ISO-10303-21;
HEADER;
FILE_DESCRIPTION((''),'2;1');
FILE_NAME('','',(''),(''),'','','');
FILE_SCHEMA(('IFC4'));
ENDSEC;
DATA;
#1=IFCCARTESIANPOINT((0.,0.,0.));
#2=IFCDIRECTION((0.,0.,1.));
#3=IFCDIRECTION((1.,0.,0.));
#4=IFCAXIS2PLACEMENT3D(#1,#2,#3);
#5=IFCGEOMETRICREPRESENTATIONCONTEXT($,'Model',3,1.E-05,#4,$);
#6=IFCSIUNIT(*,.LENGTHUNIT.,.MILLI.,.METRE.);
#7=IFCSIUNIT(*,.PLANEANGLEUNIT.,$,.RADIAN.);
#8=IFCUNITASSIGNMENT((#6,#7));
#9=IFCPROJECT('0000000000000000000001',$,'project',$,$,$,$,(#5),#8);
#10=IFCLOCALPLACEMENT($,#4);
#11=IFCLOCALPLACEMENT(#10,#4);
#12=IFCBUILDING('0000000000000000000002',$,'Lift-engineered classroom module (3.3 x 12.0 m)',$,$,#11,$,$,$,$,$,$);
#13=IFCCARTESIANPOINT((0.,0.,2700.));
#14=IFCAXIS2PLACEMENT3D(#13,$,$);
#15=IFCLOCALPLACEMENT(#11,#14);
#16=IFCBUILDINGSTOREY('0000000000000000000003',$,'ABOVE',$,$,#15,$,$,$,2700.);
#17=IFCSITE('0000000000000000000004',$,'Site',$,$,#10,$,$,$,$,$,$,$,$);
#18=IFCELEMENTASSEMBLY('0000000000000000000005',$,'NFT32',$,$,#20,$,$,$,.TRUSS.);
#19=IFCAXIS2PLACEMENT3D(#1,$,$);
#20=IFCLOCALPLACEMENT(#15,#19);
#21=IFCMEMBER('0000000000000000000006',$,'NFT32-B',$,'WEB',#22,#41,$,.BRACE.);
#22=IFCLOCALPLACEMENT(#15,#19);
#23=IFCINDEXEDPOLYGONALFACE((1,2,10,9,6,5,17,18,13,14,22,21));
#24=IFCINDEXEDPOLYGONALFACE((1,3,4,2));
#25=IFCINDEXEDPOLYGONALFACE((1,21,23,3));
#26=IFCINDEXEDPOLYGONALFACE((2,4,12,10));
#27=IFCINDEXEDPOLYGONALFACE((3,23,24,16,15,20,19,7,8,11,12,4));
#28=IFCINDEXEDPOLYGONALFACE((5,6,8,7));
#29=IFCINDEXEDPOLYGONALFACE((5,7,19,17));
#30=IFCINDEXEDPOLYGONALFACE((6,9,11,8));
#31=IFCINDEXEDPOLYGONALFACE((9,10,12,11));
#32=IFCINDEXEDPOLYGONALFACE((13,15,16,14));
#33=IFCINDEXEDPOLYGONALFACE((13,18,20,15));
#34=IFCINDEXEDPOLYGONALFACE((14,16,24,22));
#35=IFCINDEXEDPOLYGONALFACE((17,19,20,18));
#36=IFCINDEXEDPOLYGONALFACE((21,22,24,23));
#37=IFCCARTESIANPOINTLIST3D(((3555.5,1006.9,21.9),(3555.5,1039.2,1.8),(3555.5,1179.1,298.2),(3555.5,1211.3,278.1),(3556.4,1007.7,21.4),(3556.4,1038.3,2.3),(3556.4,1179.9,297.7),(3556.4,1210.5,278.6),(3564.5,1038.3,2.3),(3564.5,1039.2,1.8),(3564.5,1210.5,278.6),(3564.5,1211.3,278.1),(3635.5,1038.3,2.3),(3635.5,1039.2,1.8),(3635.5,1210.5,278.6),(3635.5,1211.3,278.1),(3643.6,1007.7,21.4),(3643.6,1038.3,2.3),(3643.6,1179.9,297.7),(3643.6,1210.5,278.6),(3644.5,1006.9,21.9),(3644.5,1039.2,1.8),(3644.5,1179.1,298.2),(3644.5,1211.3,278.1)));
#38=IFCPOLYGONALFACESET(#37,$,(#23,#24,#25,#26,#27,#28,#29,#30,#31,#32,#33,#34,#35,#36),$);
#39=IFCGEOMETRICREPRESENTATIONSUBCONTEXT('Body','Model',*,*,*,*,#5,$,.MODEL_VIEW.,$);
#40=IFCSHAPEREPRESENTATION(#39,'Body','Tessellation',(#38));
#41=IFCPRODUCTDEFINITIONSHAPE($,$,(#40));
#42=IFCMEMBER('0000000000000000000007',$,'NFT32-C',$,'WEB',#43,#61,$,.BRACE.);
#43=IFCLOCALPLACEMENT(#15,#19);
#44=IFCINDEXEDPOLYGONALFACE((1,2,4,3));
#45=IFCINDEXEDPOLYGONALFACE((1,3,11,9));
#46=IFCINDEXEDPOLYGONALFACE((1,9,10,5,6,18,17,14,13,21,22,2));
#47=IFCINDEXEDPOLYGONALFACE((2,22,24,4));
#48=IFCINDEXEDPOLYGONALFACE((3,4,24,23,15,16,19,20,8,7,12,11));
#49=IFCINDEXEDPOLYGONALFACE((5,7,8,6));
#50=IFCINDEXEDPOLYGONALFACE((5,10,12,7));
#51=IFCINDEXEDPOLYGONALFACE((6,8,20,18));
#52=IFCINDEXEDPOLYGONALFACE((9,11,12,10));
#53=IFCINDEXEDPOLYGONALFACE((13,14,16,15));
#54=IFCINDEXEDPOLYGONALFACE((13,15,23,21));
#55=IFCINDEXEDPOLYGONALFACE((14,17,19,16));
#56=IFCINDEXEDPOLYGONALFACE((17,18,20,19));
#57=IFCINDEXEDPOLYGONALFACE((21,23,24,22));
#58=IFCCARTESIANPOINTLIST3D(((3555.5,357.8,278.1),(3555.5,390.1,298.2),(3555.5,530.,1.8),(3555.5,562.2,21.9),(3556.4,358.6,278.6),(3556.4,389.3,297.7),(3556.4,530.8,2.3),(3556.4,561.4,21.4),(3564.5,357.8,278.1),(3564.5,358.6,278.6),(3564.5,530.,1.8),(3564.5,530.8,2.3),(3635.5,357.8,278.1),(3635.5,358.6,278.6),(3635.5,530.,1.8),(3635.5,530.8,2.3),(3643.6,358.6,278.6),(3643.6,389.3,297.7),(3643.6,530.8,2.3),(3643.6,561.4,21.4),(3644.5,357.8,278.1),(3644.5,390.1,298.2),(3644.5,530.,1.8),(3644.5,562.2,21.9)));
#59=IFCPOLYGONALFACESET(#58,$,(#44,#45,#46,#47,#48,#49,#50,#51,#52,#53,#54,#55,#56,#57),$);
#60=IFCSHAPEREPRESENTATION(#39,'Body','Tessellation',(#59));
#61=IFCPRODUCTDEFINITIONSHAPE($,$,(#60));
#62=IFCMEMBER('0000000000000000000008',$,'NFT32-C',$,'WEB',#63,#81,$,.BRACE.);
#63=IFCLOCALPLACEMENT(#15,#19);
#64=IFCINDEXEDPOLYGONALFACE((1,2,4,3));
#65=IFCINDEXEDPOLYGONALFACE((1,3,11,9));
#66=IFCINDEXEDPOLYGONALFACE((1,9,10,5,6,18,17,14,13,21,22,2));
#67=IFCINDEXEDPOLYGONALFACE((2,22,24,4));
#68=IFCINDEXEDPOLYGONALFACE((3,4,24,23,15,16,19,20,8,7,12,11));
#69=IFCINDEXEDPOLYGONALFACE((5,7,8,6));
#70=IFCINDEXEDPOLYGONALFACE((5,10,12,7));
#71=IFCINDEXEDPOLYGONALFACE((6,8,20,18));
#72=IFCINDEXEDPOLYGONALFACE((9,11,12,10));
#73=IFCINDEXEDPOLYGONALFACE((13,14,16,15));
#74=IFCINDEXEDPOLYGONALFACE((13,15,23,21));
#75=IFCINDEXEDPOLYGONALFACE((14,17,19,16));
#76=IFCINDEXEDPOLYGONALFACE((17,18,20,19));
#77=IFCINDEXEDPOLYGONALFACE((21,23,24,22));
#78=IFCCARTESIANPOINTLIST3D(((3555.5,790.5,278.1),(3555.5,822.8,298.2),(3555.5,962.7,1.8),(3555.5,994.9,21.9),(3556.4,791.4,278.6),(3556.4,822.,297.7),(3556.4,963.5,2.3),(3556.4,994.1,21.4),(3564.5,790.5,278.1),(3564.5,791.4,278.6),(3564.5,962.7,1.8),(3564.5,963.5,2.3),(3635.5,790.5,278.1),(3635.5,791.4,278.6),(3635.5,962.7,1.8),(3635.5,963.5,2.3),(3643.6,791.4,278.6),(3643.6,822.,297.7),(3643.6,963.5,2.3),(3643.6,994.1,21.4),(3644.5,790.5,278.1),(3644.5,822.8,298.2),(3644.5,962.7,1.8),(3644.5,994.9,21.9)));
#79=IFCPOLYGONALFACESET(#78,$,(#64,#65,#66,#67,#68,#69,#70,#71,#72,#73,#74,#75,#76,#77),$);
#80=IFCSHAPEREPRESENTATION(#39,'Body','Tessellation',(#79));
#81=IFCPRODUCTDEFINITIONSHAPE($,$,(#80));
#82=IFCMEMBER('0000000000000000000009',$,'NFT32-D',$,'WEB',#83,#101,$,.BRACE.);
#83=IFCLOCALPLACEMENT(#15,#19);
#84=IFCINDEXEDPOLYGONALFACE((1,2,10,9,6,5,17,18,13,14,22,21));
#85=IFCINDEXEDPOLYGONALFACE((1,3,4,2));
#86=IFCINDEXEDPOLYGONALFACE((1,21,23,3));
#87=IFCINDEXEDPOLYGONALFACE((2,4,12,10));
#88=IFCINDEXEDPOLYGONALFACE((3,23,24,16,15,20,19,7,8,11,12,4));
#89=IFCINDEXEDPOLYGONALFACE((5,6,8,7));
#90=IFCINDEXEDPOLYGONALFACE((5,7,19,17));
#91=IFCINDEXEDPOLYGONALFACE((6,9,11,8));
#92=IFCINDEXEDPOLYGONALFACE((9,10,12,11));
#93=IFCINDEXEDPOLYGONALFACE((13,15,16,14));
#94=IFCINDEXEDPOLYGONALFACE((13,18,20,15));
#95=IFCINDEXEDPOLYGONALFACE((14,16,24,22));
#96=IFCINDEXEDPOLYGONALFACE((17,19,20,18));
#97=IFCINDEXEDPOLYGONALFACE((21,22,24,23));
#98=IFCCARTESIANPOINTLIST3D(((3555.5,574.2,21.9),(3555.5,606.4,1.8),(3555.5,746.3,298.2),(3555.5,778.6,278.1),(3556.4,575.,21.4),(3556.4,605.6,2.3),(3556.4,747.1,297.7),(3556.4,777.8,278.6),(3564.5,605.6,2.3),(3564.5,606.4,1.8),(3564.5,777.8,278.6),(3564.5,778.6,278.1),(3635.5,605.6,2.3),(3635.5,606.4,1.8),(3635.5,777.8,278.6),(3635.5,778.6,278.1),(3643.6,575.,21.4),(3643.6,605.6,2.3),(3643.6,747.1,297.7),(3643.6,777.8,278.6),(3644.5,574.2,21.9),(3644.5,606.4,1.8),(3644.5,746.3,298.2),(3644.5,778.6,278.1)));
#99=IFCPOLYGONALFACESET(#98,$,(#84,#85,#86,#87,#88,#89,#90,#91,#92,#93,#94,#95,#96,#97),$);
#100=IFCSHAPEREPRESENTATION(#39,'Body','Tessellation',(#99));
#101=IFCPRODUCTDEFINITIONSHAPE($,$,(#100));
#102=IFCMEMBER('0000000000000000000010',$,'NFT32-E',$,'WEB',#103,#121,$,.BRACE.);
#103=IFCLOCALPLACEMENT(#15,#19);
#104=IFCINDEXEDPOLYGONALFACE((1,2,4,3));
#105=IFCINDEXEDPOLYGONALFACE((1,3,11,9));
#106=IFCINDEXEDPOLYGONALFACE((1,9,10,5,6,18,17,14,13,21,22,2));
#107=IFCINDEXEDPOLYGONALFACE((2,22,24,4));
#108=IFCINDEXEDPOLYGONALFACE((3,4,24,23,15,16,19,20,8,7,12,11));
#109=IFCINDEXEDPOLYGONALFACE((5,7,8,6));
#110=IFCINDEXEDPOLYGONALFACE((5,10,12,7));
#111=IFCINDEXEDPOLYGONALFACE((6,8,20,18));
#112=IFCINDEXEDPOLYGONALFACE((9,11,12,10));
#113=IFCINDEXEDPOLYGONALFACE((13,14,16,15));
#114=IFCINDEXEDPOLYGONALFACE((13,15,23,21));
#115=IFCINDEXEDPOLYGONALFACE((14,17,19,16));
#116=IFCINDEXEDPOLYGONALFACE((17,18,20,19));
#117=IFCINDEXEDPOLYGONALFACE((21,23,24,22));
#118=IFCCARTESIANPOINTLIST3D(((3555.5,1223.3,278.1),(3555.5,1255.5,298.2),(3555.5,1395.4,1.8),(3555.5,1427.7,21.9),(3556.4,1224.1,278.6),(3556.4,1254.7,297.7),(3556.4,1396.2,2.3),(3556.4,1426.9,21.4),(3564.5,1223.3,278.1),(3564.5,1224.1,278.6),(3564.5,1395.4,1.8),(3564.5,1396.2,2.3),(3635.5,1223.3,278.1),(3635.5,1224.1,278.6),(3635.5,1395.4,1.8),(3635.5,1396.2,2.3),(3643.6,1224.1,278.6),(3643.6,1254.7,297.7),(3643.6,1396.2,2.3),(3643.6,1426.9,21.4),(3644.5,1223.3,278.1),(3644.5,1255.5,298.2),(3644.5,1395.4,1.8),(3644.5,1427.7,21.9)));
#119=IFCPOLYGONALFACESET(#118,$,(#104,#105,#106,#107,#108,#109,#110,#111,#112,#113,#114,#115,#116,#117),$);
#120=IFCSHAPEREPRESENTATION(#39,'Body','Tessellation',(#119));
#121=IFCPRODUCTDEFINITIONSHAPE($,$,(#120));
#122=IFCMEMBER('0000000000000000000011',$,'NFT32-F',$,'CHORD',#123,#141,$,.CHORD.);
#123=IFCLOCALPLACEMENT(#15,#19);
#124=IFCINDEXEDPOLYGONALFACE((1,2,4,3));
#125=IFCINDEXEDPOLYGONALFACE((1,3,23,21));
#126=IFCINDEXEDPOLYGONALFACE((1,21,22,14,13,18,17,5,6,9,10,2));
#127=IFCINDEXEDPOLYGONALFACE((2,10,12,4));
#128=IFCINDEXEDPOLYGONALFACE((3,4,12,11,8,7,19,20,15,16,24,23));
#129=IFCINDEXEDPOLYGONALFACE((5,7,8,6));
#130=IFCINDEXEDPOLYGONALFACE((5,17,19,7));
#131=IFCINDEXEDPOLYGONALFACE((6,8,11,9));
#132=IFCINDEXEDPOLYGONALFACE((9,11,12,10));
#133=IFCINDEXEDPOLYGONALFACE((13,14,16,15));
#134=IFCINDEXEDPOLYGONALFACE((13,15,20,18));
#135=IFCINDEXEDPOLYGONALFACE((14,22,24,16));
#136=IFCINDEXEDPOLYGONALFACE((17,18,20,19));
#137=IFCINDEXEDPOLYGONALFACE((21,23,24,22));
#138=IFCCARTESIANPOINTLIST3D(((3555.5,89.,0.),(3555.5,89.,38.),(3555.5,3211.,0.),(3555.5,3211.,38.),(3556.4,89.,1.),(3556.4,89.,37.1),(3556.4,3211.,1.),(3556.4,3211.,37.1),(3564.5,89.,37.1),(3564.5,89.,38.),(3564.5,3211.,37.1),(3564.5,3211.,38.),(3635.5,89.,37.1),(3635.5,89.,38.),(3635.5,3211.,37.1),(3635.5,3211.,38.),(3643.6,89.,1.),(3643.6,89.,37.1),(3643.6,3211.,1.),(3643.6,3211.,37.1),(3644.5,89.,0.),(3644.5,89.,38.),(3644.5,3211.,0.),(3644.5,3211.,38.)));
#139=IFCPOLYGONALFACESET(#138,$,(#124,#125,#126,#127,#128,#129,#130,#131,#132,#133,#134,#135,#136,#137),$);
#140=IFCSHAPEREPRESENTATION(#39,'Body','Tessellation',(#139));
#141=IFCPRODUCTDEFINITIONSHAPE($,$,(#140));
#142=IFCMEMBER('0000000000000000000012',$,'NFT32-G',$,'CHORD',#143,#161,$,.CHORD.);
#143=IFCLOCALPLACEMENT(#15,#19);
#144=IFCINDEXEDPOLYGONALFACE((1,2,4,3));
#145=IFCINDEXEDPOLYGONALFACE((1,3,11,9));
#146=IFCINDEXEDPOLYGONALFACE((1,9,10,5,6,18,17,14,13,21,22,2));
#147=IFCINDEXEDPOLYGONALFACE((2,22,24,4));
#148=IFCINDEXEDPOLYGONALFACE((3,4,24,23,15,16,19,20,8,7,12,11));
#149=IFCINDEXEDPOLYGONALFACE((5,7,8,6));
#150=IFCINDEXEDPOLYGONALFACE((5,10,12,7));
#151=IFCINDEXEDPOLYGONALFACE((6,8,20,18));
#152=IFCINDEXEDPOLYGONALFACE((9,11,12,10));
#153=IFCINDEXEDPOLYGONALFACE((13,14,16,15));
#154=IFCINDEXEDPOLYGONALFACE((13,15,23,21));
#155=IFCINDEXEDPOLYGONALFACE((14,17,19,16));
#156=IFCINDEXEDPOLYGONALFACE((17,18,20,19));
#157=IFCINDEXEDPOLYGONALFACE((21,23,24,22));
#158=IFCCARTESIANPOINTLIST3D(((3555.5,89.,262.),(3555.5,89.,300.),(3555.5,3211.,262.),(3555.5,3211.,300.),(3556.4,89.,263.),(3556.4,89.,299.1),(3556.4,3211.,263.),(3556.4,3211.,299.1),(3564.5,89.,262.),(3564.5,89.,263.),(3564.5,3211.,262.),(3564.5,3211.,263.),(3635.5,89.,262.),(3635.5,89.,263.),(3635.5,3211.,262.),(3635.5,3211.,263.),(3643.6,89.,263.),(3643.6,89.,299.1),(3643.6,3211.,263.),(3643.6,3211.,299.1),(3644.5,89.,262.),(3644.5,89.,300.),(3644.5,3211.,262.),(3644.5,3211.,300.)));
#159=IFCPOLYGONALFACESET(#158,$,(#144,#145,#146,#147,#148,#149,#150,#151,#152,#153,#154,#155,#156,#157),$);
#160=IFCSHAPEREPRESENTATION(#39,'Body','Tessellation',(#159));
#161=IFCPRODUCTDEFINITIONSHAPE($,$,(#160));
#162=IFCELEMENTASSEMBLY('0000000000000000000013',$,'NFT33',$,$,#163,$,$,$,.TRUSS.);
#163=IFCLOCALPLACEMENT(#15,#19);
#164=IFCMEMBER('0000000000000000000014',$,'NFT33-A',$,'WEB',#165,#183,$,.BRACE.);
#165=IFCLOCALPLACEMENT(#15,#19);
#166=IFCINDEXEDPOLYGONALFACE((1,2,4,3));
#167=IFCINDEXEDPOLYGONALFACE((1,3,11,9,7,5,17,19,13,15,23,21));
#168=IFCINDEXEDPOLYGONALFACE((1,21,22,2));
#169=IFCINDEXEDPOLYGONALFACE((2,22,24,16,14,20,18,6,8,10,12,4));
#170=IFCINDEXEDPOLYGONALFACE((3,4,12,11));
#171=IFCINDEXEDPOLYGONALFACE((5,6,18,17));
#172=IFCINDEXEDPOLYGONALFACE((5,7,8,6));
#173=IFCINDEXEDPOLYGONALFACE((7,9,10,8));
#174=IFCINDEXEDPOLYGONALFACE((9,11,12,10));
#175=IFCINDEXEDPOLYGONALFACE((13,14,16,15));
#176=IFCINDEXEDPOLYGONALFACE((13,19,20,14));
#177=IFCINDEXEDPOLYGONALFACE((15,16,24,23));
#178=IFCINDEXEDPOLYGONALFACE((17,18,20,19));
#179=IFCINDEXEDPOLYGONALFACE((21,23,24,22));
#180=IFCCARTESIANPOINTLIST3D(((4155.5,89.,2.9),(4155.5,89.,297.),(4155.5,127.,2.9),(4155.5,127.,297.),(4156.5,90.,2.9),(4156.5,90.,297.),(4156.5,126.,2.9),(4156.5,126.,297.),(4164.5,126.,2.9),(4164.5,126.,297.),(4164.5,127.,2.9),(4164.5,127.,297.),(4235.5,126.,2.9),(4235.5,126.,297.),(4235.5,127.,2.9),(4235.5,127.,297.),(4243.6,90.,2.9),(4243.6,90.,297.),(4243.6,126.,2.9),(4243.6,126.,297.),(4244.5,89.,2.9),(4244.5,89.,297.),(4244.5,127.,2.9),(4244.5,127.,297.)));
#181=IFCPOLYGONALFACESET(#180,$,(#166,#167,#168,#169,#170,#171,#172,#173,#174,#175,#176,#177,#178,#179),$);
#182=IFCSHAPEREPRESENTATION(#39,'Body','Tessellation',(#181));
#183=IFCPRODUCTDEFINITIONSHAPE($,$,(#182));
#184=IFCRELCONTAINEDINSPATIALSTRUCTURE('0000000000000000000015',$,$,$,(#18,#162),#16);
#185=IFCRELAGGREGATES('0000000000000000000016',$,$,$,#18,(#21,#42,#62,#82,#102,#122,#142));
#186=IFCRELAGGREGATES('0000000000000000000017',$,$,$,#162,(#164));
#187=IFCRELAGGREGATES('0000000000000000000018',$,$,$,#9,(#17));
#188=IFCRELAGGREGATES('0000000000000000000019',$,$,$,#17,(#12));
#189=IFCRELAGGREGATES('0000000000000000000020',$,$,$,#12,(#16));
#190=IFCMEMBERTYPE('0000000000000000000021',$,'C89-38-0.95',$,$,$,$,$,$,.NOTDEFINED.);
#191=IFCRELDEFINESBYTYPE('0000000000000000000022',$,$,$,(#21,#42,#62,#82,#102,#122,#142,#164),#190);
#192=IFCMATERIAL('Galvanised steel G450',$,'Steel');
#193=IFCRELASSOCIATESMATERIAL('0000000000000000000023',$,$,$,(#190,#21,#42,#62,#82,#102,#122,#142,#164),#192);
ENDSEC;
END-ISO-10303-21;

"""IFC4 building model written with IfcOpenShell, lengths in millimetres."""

from ifc_helpers import new_model, si_unit, frame, origin, origin_with_axes, origin_2d, place, context, subcontext, project, spatial, c_section, extrude, material, material_profile, profile_set, profile_usage, type_object, element, aggregate, save


model = new_model("IFC4")

# Units and contexts
model_context = context("Model", 3, precision=1e-05, world=origin_with_axes())
body_context = subcontext(model_context, "Body", "Model", "MODEL_VIEW")
ifc_project = project(units=[si_unit("LENGTHUNIT", "METRE", prefix="MILLI"), si_unit("PLANEANGLEUNIT", "RADIAN")], contexts=[model_context])

# Site, building, storey
site_placement = place(None, origin_with_axes())
site = spatial("IfcSite", under=ifc_project, at=site_placement, Name="Site")
building_placement = place(site_placement, origin_with_axes())
building = spatial("IfcBuilding", under=site, at=building_placement, Name="Lift-engineered classroom module (3.3 x 12.0 m)")
storey_placement = place(building_placement, frame((0.0, 0.0, 2700.0)))
storey = spatial("IfcBuildingStorey", under=building, at=storey_placement, Name="ABOVE", Elevation=2700.0)

# Element assemblies, members
ifc_material = material(Name="Galvanised steel G450", Category="Steel")
ifc_material_profile = material_profile(ifc_material, c_section(Depth=89.0, Width=38.0, WallThickness=0.9, Girth=9.0, at=origin_2d()), Name="C89-38-0.95")
ifc_profile_set = profile_set([ifc_material_profile], Name="C89-38-0.95")
ifc_profile_usage = profile_usage(ifc_profile_set)
member_type = type_object("IfcMemberType", Name="C89-38-0.95", PredefinedType="NOTDEFINED", material=ifc_profile_set)
assembly_1_placement = place(storey_placement, frame((3600.0, 89.0, 0.0)))
assembly_1 = element("IfcElementAssembly", 1, at=assembly_1_placement, inside=storey, Name="NFT32", PredefinedType="TRUSS")
member_1_placement = place(assembly_1_placement, frame((0.0, 934.0, 11.8), z_axis=(0.0, 0.528797, 0.848748), x_axis=(0.0, 0.848748, -0.528797)))
member_1 = element("IfcMember", 2, at=member_1_placement, type_object=member_type, material=ifc_profile_usage, Name="NFT32-B", ObjectType="WEB", PredefinedType="BRACE", context=body_context, shape_type="SweptSolid", body=[
    extrude(c_section(Depth=89.0, Width=38.0, WallThickness=0.9, Girth=9.0, at=origin_2d()), origin(), (0.0, 0.0, 1.0), 325.6),
])
member_2_placement = place(assembly_1_placement, frame((0.0, 457.1, 11.8), z_axis=(0.0, -0.528797, 0.848748), x_axis=(0.0, -0.848748, -0.528797)))
member_2 = element("IfcMember", 3, at=member_2_placement, type_object=member_type, material=ifc_profile_usage, Name="NFT32-C", ObjectType="WEB", PredefinedType="BRACE", context=body_context, shape_type="SweptSolid", body=[
    extrude(c_section(Depth=89.0, Width=38.0, WallThickness=0.9, Girth=9.0, at=origin_2d()), origin(), (0.0, 0.0, 1.0), 325.6),
])
member_3_placement = place(assembly_1_placement, frame((0.0, 889.8, 11.8), z_axis=(0.0, -0.528797, 0.848748), x_axis=(0.0, -0.848748, -0.528797)))
member_3 = element("IfcMember", 4, at=member_3_placement, type_object=member_type, material=ifc_profile_usage, Name="NFT32-C", ObjectType="WEB", PredefinedType="BRACE", context=body_context, shape_type="SweptSolid", body=[
    extrude(c_section(Depth=89.0, Width=38.0, WallThickness=0.9, Girth=9.0, at=origin_2d()), origin(), (0.0, 0.0, 1.0), 325.6),
])
member_4_placement = place(assembly_1_placement, frame((0.0, 501.3, 11.8), z_axis=(0.0, 0.528775, 0.848762), x_axis=(0.0, 0.848762, -0.528775)))
member_4 = element("IfcMember", 5, at=member_4_placement, type_object=member_type, material=ifc_profile_usage, Name="NFT32-D", ObjectType="WEB", PredefinedType="BRACE", context=body_context, shape_type="SweptSolid", body=[
    extrude(c_section(Depth=89.0, Width=38.0, WallThickness=0.9, Girth=9.0, at=origin_2d()), origin(), (0.0, 0.0, 1.0), 325.6),
])
member_5_placement = place(assembly_1_placement, frame((0.0, 1322.5, 11.8), z_axis=(0.0, -0.528775, 0.848762), x_axis=(0.0, -0.848762, -0.528775)))
member_5 = element("IfcMember", 6, at=member_5_placement, type_object=member_type, material=ifc_profile_usage, Name="NFT32-E", ObjectType="WEB", PredefinedType="BRACE", context=body_context, shape_type="SweptSolid", body=[
    extrude(c_section(Depth=89.0, Width=38.0, WallThickness=0.9, Girth=9.0, at=origin_2d()), origin(), (0.0, 0.0, 1.0), 325.6),
])
member_6_placement = place(assembly_1_placement, frame((0.0, 0.0, 19.0), z_axis=(0.0, 1.0, 0.0), x_axis=(0.0, 0.0, 1.0)))
member_6 = element("IfcMember", 7, at=member_6_placement, type_object=member_type, material=ifc_profile_usage, Name="NFT32-F", ObjectType="CHORD", PredefinedType="CHORD", context=body_context, shape_type="SweptSolid", body=[
    extrude(c_section(Depth=89.0, Width=38.0, WallThickness=0.9, Girth=9.0, at=origin_2d()), origin(), (0.0, 0.0, 1.0), 3122.0),
])
member_7_placement = place(assembly_1_placement, frame((0.0, 0.0, 281.0), z_axis=(0.0, 1.0, 0.0), x_axis=(0.0, 0.0, -1.0)))
member_7 = element("IfcMember", 8, at=member_7_placement, type_object=member_type, material=ifc_profile_usage, Name="NFT32-G", ObjectType="CHORD", PredefinedType="CHORD", context=body_context, shape_type="SweptSolid", body=[
    extrude(c_section(Depth=89.0, Width=38.0, WallThickness=0.9, Girth=9.0, at=origin_2d()), origin(), (0.0, 0.0, 1.0), 3122.0),
])
aggregate(assembly_1, [member_1, member_2, member_3, member_4, member_5, member_6, member_7])
assembly_2_placement = place(storey_placement, frame((4200.0, 89.0, 0.0)))
assembly_2 = element("IfcElementAssembly", 9, at=assembly_2_placement, inside=storey, Name="NFT33", PredefinedType="TRUSS")
member_8_placement = place(assembly_2_placement, frame((0.0, 19.0, 2.9), z_axis=(0.0, 0.0, 1.0), x_axis=(0.0, 1.0, 0.0)))
member_8 = element("IfcMember", 10, at=member_8_placement, type_object=member_type, material=ifc_profile_usage, Name="NFT33-A", ObjectType="WEB", PredefinedType="BRACE", context=body_context, shape_type="SweptSolid", body=[
    extrude(c_section(Depth=89.0, Width=38.0, WallThickness=0.9, Girth=9.0, at=origin_2d()), origin(), (0.0, 0.0, 1.0), 294.1),
])
aggregate(assembly_2, [member_8])

save(model, "model.ifc")
